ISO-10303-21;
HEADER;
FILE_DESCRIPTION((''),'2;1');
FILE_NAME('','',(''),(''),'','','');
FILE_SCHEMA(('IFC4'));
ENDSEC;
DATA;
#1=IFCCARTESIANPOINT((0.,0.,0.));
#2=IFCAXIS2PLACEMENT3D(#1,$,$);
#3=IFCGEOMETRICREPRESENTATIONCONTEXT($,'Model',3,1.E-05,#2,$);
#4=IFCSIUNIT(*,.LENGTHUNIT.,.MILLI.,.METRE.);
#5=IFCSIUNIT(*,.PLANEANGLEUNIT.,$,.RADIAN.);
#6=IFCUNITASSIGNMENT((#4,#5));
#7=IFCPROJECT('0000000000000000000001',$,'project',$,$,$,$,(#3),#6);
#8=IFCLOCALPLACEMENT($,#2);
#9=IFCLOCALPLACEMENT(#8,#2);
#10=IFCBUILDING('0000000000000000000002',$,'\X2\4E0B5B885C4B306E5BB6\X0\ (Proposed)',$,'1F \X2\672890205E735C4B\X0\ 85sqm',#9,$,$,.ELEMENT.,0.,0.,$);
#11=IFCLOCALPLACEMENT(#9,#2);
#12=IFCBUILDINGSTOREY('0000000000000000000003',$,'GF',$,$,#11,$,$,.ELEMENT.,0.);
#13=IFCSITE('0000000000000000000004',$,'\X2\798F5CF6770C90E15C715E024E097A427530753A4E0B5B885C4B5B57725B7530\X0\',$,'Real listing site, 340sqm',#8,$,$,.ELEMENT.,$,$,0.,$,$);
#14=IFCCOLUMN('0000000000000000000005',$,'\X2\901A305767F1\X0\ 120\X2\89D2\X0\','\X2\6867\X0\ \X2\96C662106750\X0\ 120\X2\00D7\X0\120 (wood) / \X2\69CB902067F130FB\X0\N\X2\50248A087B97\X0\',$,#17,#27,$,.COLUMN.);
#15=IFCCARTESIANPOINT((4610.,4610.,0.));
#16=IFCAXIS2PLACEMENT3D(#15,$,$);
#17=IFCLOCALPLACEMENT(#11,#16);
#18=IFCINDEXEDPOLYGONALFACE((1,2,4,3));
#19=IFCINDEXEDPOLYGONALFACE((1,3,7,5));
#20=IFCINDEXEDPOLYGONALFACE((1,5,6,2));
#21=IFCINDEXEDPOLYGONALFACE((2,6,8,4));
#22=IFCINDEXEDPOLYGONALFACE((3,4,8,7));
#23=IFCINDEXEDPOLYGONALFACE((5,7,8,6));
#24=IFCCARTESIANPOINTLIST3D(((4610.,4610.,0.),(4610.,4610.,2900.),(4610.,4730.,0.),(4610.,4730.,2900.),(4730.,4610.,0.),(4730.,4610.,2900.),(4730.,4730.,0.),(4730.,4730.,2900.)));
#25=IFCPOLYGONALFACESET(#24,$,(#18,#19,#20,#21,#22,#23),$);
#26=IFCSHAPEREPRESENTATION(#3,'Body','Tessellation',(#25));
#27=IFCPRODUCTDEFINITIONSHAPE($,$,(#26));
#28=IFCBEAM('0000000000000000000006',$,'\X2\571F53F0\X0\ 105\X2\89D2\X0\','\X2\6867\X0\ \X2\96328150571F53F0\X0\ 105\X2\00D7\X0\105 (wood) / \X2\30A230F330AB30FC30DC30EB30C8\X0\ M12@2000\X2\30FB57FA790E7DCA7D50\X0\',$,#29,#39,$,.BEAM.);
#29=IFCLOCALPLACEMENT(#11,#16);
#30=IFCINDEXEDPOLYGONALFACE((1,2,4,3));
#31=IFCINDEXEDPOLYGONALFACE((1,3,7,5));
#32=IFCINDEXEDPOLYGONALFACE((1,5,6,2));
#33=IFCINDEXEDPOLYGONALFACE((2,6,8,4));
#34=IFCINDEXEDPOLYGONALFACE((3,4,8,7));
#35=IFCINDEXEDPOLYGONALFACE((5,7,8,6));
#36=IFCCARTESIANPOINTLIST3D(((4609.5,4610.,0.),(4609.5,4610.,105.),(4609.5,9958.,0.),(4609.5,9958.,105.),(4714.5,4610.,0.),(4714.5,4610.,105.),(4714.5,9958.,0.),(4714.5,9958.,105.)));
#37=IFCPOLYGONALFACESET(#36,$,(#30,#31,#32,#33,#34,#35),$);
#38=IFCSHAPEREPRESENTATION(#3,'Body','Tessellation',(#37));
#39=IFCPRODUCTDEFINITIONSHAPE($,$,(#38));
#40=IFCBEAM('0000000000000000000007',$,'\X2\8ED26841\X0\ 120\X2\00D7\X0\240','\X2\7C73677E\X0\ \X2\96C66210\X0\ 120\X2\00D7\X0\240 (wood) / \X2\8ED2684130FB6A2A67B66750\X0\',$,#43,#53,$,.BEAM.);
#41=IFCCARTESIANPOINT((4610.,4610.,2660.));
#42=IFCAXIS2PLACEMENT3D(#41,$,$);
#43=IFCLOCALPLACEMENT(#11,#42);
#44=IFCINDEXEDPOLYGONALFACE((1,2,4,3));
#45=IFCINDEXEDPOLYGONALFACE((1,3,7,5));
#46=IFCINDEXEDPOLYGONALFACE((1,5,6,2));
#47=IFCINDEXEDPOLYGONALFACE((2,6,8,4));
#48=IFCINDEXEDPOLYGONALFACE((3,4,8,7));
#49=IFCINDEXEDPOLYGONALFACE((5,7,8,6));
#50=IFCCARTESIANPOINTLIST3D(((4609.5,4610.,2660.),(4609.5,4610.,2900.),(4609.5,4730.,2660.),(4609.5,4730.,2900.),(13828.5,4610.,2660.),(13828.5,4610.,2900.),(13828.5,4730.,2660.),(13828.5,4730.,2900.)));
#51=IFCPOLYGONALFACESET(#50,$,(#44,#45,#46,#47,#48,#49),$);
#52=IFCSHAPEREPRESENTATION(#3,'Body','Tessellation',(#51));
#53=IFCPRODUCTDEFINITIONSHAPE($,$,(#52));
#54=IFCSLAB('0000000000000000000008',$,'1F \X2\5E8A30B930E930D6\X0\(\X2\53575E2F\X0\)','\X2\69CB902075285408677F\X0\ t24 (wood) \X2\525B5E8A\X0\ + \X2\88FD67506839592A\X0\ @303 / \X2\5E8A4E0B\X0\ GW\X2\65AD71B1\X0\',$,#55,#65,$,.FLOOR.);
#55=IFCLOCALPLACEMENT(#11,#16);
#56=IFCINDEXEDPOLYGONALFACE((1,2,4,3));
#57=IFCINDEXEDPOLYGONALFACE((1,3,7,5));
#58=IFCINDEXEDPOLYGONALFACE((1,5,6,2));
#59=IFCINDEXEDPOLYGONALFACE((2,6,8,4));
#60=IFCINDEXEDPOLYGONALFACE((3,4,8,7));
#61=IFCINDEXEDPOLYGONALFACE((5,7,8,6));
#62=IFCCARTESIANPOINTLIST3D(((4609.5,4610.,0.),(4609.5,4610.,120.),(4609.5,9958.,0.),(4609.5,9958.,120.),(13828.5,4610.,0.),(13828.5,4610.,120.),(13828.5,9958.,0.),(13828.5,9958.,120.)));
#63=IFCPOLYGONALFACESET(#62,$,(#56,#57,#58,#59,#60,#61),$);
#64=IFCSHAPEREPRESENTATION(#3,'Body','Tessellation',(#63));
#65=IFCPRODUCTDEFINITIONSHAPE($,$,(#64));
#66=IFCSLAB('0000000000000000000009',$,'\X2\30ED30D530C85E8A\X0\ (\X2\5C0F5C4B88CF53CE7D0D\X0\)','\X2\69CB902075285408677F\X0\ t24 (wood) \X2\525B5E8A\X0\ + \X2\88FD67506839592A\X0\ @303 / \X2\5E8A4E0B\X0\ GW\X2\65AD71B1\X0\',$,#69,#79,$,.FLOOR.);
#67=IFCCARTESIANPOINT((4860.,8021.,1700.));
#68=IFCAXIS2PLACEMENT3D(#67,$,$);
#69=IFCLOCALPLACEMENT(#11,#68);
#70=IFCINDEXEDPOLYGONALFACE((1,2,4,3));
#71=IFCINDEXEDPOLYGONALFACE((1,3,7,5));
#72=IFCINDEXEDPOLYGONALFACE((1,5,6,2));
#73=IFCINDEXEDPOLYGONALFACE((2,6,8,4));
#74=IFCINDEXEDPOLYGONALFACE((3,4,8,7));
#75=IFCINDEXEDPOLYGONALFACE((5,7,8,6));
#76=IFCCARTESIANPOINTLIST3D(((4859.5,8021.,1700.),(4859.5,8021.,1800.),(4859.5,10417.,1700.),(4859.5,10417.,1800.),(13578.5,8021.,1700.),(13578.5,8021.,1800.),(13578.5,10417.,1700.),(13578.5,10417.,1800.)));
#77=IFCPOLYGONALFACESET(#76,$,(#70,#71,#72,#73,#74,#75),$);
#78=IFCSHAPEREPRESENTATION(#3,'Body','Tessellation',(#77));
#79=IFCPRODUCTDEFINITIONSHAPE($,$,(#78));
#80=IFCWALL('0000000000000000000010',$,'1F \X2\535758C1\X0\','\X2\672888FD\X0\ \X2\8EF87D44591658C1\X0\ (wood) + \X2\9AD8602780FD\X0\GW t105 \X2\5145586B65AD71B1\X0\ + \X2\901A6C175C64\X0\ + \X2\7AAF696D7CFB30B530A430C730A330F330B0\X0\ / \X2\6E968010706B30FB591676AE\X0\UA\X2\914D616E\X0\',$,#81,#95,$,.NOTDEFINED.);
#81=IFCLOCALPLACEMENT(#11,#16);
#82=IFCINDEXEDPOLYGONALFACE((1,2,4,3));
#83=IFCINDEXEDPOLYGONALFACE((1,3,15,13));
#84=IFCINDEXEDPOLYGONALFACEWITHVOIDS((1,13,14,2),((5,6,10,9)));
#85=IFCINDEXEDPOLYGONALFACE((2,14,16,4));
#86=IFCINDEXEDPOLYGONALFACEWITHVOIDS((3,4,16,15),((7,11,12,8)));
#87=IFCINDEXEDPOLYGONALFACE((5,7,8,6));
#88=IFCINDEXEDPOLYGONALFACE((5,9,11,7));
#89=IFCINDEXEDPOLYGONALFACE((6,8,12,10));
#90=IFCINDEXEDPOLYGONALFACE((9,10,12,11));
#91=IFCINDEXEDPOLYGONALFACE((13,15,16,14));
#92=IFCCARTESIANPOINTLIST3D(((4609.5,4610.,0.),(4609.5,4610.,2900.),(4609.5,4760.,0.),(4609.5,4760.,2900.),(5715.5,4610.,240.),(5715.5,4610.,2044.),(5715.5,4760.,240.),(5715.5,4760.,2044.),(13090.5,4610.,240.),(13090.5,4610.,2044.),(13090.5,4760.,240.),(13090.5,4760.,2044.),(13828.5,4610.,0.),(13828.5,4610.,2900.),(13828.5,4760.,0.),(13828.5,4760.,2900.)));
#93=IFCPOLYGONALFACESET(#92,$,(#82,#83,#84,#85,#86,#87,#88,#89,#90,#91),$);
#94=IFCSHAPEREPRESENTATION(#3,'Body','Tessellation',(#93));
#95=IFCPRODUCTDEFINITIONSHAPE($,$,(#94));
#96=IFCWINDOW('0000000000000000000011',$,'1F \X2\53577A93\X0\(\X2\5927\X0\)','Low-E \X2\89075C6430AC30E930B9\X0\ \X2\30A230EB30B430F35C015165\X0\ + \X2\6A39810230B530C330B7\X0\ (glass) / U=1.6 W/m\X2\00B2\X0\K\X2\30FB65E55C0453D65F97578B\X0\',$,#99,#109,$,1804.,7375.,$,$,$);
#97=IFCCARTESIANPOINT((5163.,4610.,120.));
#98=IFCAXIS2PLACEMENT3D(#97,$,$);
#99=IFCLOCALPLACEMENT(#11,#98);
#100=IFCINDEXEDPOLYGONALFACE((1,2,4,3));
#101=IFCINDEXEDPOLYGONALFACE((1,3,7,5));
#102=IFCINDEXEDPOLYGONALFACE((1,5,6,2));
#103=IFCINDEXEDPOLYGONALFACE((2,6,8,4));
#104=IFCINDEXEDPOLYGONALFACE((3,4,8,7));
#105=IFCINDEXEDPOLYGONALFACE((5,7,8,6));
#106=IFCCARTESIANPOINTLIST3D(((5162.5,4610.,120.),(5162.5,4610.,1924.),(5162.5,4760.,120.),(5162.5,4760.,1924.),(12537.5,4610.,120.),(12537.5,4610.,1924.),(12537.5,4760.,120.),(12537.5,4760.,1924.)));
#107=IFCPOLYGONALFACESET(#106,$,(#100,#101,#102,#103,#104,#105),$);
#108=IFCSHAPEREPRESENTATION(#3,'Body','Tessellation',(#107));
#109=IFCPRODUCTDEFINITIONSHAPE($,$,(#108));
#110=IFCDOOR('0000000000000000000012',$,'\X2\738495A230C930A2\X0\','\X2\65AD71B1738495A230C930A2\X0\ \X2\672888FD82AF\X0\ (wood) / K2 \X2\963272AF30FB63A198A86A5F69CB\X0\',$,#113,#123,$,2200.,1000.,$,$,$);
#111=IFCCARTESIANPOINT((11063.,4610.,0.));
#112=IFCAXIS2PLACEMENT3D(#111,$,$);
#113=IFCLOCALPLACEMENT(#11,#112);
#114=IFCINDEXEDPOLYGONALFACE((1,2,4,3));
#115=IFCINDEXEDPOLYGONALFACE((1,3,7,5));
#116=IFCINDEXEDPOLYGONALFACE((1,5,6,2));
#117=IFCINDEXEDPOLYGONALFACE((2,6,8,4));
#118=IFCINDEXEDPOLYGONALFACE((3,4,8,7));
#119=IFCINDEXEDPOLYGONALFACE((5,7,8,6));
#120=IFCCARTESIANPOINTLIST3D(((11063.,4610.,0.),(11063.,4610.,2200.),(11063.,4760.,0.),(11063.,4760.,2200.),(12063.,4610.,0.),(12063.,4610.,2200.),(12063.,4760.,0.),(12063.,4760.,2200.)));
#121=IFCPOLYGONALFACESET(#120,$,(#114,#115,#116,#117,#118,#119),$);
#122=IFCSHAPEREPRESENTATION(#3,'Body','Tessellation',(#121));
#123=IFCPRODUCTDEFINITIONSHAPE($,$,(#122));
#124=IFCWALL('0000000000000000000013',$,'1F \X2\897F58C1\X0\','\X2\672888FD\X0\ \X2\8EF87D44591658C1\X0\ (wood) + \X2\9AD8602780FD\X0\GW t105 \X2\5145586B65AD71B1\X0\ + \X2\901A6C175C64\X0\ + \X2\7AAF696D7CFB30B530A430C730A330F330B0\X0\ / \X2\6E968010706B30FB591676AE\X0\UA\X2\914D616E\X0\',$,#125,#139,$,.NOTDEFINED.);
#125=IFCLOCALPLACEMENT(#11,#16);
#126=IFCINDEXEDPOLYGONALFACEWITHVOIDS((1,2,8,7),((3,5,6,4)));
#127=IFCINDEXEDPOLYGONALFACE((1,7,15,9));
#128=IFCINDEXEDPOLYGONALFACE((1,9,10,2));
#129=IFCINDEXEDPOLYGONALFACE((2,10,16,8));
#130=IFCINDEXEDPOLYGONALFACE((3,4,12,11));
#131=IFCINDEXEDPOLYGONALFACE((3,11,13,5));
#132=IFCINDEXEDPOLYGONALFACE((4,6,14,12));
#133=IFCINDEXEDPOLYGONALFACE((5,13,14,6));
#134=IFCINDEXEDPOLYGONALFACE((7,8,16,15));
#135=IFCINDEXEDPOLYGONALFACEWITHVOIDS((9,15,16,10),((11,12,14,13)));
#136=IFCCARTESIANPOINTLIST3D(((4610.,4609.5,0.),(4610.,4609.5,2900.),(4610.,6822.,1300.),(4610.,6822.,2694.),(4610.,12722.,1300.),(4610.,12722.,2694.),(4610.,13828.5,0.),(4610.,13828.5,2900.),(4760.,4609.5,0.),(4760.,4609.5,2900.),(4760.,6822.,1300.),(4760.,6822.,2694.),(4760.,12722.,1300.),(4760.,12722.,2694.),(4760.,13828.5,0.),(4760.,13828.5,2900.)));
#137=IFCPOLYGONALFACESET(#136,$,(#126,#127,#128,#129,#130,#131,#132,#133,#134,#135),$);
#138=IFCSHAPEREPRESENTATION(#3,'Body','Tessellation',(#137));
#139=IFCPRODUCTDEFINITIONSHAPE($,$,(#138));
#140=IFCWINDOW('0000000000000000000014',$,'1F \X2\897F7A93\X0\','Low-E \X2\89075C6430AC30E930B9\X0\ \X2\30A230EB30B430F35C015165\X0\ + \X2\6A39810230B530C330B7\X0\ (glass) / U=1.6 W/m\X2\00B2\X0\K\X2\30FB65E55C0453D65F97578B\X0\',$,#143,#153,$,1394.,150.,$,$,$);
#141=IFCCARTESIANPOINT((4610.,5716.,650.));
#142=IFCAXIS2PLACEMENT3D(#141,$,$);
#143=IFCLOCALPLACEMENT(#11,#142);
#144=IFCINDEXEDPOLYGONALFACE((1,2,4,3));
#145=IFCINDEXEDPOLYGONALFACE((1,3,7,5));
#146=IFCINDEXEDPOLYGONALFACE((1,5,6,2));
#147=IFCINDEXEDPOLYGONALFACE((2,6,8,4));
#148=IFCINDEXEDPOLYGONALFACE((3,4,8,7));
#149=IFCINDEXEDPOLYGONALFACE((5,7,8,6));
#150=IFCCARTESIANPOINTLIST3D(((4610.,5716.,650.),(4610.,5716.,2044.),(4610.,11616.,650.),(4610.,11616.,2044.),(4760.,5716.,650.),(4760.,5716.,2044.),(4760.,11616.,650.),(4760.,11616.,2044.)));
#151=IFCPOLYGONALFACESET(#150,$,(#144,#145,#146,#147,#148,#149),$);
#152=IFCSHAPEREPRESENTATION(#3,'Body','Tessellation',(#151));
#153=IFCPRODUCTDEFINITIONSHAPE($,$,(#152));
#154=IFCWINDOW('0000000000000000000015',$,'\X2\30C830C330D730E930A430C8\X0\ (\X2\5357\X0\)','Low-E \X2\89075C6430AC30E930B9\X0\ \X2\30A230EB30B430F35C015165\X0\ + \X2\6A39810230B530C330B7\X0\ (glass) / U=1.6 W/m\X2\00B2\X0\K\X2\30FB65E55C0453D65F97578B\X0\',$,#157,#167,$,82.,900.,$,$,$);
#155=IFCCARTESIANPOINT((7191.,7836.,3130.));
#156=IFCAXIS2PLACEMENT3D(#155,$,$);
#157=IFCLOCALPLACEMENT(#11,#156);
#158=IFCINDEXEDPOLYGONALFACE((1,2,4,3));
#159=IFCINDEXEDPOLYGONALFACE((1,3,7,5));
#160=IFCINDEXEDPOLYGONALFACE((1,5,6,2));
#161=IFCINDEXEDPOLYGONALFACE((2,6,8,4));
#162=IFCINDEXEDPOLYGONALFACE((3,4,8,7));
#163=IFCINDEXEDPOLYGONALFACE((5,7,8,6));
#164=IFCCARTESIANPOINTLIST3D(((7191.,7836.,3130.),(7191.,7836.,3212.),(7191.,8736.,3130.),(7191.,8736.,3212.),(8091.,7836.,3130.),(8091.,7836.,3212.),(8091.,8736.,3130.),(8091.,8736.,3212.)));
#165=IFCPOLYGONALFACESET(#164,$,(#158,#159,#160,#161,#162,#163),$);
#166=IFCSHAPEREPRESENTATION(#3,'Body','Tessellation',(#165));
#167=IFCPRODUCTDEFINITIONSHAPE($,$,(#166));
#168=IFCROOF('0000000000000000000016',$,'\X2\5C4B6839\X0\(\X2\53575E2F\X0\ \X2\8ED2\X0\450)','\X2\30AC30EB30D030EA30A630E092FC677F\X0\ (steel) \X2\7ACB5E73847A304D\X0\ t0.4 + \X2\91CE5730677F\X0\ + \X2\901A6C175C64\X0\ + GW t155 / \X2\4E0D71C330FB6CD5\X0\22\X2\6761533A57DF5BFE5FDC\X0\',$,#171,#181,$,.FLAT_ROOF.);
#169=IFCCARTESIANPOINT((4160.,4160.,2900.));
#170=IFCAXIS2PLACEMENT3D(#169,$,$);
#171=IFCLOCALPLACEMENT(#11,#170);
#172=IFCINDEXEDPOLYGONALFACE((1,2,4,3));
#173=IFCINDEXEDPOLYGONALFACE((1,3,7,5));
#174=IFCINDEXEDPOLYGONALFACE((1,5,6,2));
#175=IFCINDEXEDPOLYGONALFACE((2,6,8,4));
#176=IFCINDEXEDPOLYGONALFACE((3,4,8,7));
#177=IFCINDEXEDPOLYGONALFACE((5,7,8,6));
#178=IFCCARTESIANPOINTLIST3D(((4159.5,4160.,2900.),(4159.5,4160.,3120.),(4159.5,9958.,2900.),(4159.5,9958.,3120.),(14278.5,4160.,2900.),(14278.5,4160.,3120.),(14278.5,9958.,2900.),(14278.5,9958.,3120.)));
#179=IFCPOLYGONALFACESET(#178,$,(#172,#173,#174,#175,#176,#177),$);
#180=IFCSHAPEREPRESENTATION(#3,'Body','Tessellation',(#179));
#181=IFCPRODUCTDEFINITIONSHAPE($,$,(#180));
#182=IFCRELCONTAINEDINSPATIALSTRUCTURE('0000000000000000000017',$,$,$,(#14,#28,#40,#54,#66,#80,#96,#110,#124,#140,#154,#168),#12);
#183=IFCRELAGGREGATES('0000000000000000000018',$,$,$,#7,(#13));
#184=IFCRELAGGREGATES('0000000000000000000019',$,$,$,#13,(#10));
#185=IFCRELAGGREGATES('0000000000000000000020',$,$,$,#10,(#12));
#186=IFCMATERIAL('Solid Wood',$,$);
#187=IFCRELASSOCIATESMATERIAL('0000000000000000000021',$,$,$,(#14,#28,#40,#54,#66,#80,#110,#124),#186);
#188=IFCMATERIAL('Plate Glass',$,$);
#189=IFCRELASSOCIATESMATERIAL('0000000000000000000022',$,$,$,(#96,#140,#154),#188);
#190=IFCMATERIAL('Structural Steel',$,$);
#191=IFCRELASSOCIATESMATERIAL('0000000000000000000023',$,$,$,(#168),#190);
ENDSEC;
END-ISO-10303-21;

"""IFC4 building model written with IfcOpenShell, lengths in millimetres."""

from ifc_helpers import new_model, si_unit, frame, frame_2d, origin, place, context, project, spatial, rectangle, extrude, material, element, fill, save


model = new_model("IFC4")

# Units and contexts
model_context = context("Model", 3, precision=1e-05, world=origin())
ifc_project = project(units=[si_unit("LENGTHUNIT", "METRE", prefix="MILLI"), si_unit("PLANEANGLEUNIT", "RADIAN")], contexts=[model_context])

# Site, building, storey
site_placement = place(None, origin())
site = spatial("IfcSite", under=ifc_project, at=site_placement, Name="福島県郡山市三穂田町下守屋字牛田", ObjectType="Real listing site, 340sqm", CompositionType="ELEMENT", RefElevation=0.0)
building_placement = place(site_placement, origin())
building = spatial("IfcBuilding", under=site, at=building_placement, Name="下守屋の家 (Proposed)", ObjectType="1F 木造平屋 85sqm", CompositionType="ELEMENT", ElevationOfRefHeight=0.0, ElevationOfTerrain=0.0)
storey_placement = place(building_placement, origin())
storey = spatial("IfcBuildingStorey", under=building, at=storey_placement, Name="GF", CompositionType="ELEMENT", Elevation=0.0)

# Column
ifc_material_1 = material(Name="Solid Wood")
column_1_placement = place(storey_placement, frame((4610.0, 4610.0, 0.0)))
element("IfcColumn", 1, at=column_1_placement, inside=storey, material=ifc_material_1, Name="通し柱 120角", Description="桧 集成材 120×120 (wood) / 構造柱・N値計算", PredefinedType="COLUMN", context=model_context, shape_type="SweptSolid", body=[
    extrude(rectangle(XDim=120.0, YDim=120.0, at=frame_2d((60.0, 60.0))), frame((4610.0, 4610.0, 0.0)), (0.0, 0.0, 1.0), 2900.0),
])

# Beams
beam_1_placement = place(storey_placement, frame((4610.0, 4610.0, 0.0)))
element("IfcBeam", 2, at=beam_1_placement, inside=storey, material=ifc_material_1, Name="土台 105角", Description="桧 防腐土台 105×105 (wood) / アンカーボルト M12@2000・基礎緊結", PredefinedType="BEAM", context=model_context, shape_type="SweptSolid", body=[
    extrude(rectangle(XDim=105.0, YDim=5348.0, at=frame_2d((52.0, 2674.0))), frame((4610.0, 4610.0, 0.0)), (0.0, 0.0, 1.0), 105.0),
])
beam_2_placement = place(storey_placement, frame((4610.0, 4610.0, 2660.0)))
element("IfcBeam", 3, at=beam_2_placement, inside=storey, material=ifc_material_1, Name="軒桁 120×240", Description="米松 集成 120×240 (wood) / 軒桁・横架材", PredefinedType="BEAM", context=model_context, shape_type="SweptSolid", body=[
    extrude(rectangle(XDim=9219.0, YDim=120.0, at=frame_2d((4609.0, 60.0))), frame((4610.0, 4610.0, 2660.0)), (0.0, 0.0, 1.0), 240.0),
])

# Slabs
slab_1_placement = place(storey_placement, frame((4610.0, 4610.0, 0.0)))
element("IfcSlab", 4, at=slab_1_placement, inside=storey, material=ifc_material_1, Name="1F 床スラブ(南帯)", Description="構造用合板 t24 (wood) 剛床 + 製材根太 @303 / 床下 GW断熱", PredefinedType="FLOOR", context=model_context, shape_type="SweptSolid", body=[
    extrude(rectangle(XDim=9219.0, YDim=5348.0, at=frame_2d((4609.0, 2674.0))), frame((4610.0, 4610.0, 0.0)), (0.0, 0.0, 1.0), 120.0),
])
slab_2_placement = place(storey_placement, frame((4860.0, 8021.0, 1700.0)))
element("IfcSlab", 5, at=slab_2_placement, inside=storey, material=ifc_material_1, Name="ロフト床 (小屋裏収納)", Description="構造用合板 t24 (wood) 剛床 + 製材根太 @303 / 床下 GW断熱", PredefinedType="FLOOR", context=model_context, shape_type="SweptSolid", body=[
    extrude(rectangle(XDim=8719.0, YDim=2396.0, at=frame_2d((4359.0, 1198.0))), frame((4860.0, 8021.0, 1700.0)), (0.0, 0.0, 1.0), 100.0),
])

# Wall, openings, window, door
wall_1_placement = place(storey_placement, frame((4610.0, 4610.0, 0.0)))
wall_1 = element("IfcWall", 6, at=wall_1_placement, inside=storey, material=ifc_material_1, Name="1F 南壁", Description="木製 軸組外壁 (wood) + 高性能GW t105 充填断熱 + 通気層 + 窯業系サイディング / 準耐火・外皮UA配慮", PredefinedType="NOTDEFINED", context=model_context, shape_type="SweptSolid", body=[
    extrude(rectangle(XDim=9219.0, YDim=150.0, at=frame_2d((4609.0, 75.0))), frame((4610.0, 4610.0, 0.0)), (0.0, 0.0, 1.0), 2900.0),
])
opening_1_placement = place(storey_placement, frame((5163.0, 4610.0, 120.0)))
opening_1 = element("IfcOpeningElement", 7, at=opening_1_placement, cuts=wall_1, PredefinedType="NOTDEFINED", context=model_context, shape_type="SweptSolid", body=[
    extrude(rectangle(XDim=7375.0, YDim=150.0, at=frame_2d((3687.0, 75.0))), frame((5163.0, 4610.0, 120.0)), (0.0, 0.0, 1.0), 1804.0),
])
opening_2_placement = place(storey_placement, frame((11063.0, 4610.0, 0.0)))
opening_2 = element("IfcOpeningElement", 8, at=opening_2_placement, cuts=wall_1, PredefinedType="NOTDEFINED", context=model_context, shape_type="SweptSolid", body=[
    extrude(rectangle(XDim=1000.0, YDim=150.0, at=frame_2d((500.0, 75.0))), frame((11063.0, 4610.0, 0.0)), (0.0, 0.0, 1.0), 2200.0),
])
ifc_material_2 = material(Name="Plate Glass")
window_1_placement = place(storey_placement, frame((5163.0, 4610.0, 120.0)))
window_1 = element("IfcWindow", 9, at=window_1_placement, inside=storey, material=ifc_material_2, Name="1F 南窓(大)", Description="Low-E 複層ガラス アルゴン封入 + 樹脂サッシ (glass) / U=1.6 W/m²K・日射取得型", OverallHeight=1804.0, OverallWidth=7375.0, context=model_context, shape_type="SweptSolid", body=[
    extrude(rectangle(XDim=7375.0, YDim=150.0, at=frame_2d((3687.0, 75.0))), frame((5163.0, 4610.0, 120.0)), (0.0, 0.0, 1.0), 1804.0),
])
fill(opening_1, window_1)
door_1_placement = place(storey_placement, frame((11063.0, 4610.0, 0.0)))
door_1 = element("IfcDoor", 10, at=door_1_placement, inside=storey, material=ifc_material_1, Name="玄関ドア", Description="断熱玄関ドア 木製芯 (wood) / K2 防犯・採風機構", OverallHeight=2200.0, OverallWidth=1000.0, context=model_context, shape_type="SweptSolid", body=[
    extrude(rectangle(XDim=1000.0, YDim=150.0, at=frame_2d((500.0, 75.0))), frame((11063.0, 4610.0, 0.0)), (0.0, 0.0, 1.0), 2200.0),
])
fill(opening_2, door_1)

# Wall, opening, window
wall_2_placement = place(storey_placement, frame((4610.0, 4610.0, 0.0)))
wall_2 = element("IfcWall", 11, at=wall_2_placement, inside=storey, material=ifc_material_1, Name="1F 西壁", Description="木製 軸組外壁 (wood) + 高性能GW t105 充填断熱 + 通気層 + 窯業系サイディング / 準耐火・外皮UA配慮", PredefinedType="NOTDEFINED", context=model_context, shape_type="SweptSolid", body=[
    extrude(rectangle(XDim=150.0, YDim=9219.0, at=frame_2d((75.0, 4609.0))), frame((4610.0, 4610.0, 0.0)), (0.0, 0.0, 1.0), 2900.0),
])
opening_3_placement = place(storey_placement, frame((4610.0, 5716.0, 650.0)))
opening_3 = element("IfcOpeningElement", 12, at=opening_3_placement, cuts=wall_2, PredefinedType="NOTDEFINED", context=model_context, shape_type="SweptSolid", body=[
    extrude(rectangle(XDim=150.0, YDim=5900.0, at=frame_2d((75.0, 2950.0))), frame((4610.0, 5716.0, 650.0)), (0.0, 0.0, 1.0), 1394.0),
])
window_2_placement = place(storey_placement, frame((4610.0, 5716.0, 650.0)))
window_2 = element("IfcWindow", 13, at=window_2_placement, inside=storey, material=ifc_material_2, Name="1F 西窓", Description="Low-E 複層ガラス アルゴン封入 + 樹脂サッシ (glass) / U=1.6 W/m²K・日射取得型", OverallHeight=1394.0, OverallWidth=150.0, context=model_context, shape_type="SweptSolid", body=[
    extrude(rectangle(XDim=150.0, YDim=5900.0, at=frame_2d((75.0, 2950.0))), frame((4610.0, 5716.0, 650.0)), (0.0, 0.0, 1.0), 1394.0),
])
fill(opening_3, window_2)

# Window
window_3_placement = place(storey_placement, frame((7191.0, 7836.0, 3130.0)))
element("IfcWindow", 14, at=window_3_placement, inside=storey, material=ifc_material_2, Name="トップライト (南)", Description="Low-E 複層ガラス アルゴン封入 + 樹脂サッシ (glass) / U=1.6 W/m²K・日射取得型", OverallHeight=82.0, OverallWidth=900.0, context=model_context, shape_type="SweptSolid", body=[
    extrude(rectangle(XDim=900.0, YDim=900.0, at=frame_2d((450.0, 450.0))), frame((7191.0, 7836.0, 3130.0)), (0.0, 0.0, 1.0), 82.0),
])

# Roof
ifc_material_3 = material(Name="Structural Steel")
roof_placement = place(storey_placement, frame((4160.0, 4160.0, 2900.0)))
element("IfcRoof", 15, at=roof_placement, inside=storey, material=ifc_material_3, Name="屋根(南帯 軒450)", Description="ガルバリウム鋼板 (steel) 立平葺き t0.4 + 野地板 + 通気層 + GW t155 / 不燃・法22条区域対応", PredefinedType="FLAT_ROOF", context=model_context, shape_type="SweptSolid", body=[
    extrude(rectangle(XDim=10119.0, YDim=5798.0, at=frame_2d((5059.0, 2899.0))), frame((4160.0, 4160.0, 2900.0)), (0.0, 0.0, 1.0), 220.0),
])

save(model, "model.ifc")
